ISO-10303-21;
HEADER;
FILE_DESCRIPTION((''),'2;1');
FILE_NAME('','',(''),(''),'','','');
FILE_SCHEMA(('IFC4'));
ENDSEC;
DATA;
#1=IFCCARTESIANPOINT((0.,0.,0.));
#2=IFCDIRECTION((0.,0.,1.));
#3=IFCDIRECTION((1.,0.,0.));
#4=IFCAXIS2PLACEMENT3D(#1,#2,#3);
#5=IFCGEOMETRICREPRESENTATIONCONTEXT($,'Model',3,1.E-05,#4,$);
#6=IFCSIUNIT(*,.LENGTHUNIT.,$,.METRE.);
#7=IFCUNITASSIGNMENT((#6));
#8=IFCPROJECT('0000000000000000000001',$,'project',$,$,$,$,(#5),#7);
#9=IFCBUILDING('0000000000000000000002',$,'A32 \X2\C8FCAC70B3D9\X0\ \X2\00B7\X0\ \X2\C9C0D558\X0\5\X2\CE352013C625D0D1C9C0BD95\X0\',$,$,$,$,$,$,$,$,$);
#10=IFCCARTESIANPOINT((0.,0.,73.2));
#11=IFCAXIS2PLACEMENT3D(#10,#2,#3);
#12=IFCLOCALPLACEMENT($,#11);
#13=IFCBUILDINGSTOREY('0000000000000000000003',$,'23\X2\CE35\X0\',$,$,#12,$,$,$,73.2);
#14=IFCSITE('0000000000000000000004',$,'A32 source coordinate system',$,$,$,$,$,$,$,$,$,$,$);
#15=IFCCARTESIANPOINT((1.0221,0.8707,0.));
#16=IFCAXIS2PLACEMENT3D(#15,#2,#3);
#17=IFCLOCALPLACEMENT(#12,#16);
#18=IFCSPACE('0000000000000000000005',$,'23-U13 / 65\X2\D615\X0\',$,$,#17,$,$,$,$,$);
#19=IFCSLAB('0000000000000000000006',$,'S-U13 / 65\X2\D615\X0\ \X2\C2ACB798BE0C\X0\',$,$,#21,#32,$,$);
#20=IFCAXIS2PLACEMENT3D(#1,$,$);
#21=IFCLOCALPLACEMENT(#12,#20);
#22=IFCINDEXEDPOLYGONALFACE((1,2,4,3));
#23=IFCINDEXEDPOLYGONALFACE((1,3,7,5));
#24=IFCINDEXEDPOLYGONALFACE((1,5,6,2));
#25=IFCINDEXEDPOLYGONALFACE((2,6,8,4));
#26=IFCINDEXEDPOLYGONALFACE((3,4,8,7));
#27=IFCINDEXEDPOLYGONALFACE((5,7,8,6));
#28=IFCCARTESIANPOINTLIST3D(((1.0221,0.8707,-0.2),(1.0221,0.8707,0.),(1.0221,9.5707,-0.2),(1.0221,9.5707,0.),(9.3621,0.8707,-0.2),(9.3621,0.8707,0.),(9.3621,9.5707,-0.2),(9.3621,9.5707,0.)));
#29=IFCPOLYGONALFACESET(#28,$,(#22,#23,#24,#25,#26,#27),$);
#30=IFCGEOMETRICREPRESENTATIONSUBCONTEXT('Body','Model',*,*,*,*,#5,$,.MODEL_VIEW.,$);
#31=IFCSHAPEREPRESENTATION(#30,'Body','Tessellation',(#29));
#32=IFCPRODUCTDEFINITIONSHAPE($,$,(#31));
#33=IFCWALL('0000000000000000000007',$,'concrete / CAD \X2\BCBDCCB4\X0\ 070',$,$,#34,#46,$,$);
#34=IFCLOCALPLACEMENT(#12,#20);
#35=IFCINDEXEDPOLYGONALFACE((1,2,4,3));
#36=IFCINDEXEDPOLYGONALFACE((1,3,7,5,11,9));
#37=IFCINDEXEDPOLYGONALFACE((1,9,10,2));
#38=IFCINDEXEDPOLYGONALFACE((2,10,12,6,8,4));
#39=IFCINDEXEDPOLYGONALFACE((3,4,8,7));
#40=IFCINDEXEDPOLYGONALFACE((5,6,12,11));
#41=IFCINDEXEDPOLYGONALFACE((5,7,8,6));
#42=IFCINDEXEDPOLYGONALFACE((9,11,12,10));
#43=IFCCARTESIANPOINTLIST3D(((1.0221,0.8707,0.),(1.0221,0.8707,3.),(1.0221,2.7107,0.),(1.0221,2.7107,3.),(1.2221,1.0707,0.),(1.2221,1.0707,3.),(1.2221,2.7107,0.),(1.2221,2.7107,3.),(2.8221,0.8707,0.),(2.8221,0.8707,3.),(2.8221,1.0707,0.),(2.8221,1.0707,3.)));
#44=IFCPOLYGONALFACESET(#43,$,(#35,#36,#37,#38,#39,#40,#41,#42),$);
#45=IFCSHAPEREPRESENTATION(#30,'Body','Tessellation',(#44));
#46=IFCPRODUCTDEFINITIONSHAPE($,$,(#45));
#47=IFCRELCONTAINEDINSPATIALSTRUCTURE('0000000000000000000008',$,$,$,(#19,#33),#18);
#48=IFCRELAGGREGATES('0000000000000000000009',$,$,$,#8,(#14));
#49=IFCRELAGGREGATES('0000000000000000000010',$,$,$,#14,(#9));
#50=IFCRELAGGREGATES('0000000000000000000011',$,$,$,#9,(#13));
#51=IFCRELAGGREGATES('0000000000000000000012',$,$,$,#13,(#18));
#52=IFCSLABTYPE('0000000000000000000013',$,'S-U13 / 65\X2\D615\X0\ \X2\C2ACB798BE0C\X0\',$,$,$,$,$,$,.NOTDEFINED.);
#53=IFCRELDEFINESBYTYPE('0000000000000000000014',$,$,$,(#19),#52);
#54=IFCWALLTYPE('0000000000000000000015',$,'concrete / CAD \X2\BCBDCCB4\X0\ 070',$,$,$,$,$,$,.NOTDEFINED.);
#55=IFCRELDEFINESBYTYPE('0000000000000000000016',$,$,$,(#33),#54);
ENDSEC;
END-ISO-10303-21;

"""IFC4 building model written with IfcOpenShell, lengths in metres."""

from ifc_helpers import new_model, si_unit, frame, origin, origin_with_axes, place, context, subcontext, project, spatial, polyline, outline, extrude, source, transform, mapped, type_object, type_shapes, element, save


model = new_model("IFC4")

# Units and contexts
model_context = context("Model", 3, precision=1e-05, world=origin_with_axes())
body_context = subcontext(model_context, "Body", "Model", "MODEL_VIEW")
ifc_project = project(units=[si_unit("LENGTHUNIT", "METRE")], contexts=[model_context])

# Site, building, storey, space
site = spatial("IfcSite", under=ifc_project, Name="A32 source coordinate system")
building = spatial("IfcBuilding", under=site, Name="A32 주거동 · 지하5층–옥탑지붕")
storey_placement = place(None, frame((0.0, 0.0, 73.2), z_axis=(0.0, 0.0, 1.0), x_axis=(1.0, 0.0, 0.0)))
storey = spatial("IfcBuildingStorey", under=building, at=storey_placement, Name="23층", Elevation=73.2)
space_placement = place(storey_placement, frame((1.0221, 0.8707, 0.0), z_axis=(0.0, 0.0, 1.0), x_axis=(1.0, 0.0, 0.0)))
space = spatial("IfcSpace", under=storey, at=space_placement, Name="23-U13 / 65형")

# Slab
slab_type = type_object("IfcSlabType", Name="S-U13 / 65형 슬래브", PredefinedType="NOTDEFINED")
shared_shape_1 = source(origin(), body_context, "Body", "SweptSolid", [
    extrude(outline(polyline([(0.0, 0.0), (0.0, 8.7), (8.34, 8.7), (8.34, 0.0), (0.0, 0.0)])), frame((0.0, 0.0, -0.2)), (0.0, 0.0, 1.0), 0.2),
])
type_shapes(slab_type, [shared_shape_1])
slab_placement = place(space_placement, origin_with_axes())
element("IfcSlab", 1, at=slab_placement, inside=space, type_object=slab_type, Name="S-U13 / 65형 슬래브", context=body_context, shape_type="MappedRepresentation", body=[
    mapped(shared_shape_1, transform((0.0, 0.0, 0.0), scale=1.0)),
])

# Wall
wall_type_1 = type_object("IfcWallType", Name="concrete / CAD 벽체 070", PredefinedType="NOTDEFINED")
shared_shape_2 = source(origin(), body_context, "Body", "SweptSolid", [
    extrude(outline(polyline([(0.2, 1.84), (0.2, 0.2), (1.8, 0.2), (1.8, 0.0), (0.0, 0.0), (0.0, 1.84), (0.2, 1.84)])), origin(), (0.0, 0.0, 1.0), 3.0),
])
type_shapes(wall_type_1, [shared_shape_2])
wall_1_placement = place(space_placement, origin_with_axes())
element("IfcWall", 2, at=wall_1_placement, inside=space, type_object=wall_type_1, Name="concrete / CAD 벽체 070", context=body_context, shape_type="MappedRepresentation", body=[
    mapped(shared_shape_2, transform((0.0, 0.0, 0.0), scale=1.0)),
])

save(model, "model.ifc")
